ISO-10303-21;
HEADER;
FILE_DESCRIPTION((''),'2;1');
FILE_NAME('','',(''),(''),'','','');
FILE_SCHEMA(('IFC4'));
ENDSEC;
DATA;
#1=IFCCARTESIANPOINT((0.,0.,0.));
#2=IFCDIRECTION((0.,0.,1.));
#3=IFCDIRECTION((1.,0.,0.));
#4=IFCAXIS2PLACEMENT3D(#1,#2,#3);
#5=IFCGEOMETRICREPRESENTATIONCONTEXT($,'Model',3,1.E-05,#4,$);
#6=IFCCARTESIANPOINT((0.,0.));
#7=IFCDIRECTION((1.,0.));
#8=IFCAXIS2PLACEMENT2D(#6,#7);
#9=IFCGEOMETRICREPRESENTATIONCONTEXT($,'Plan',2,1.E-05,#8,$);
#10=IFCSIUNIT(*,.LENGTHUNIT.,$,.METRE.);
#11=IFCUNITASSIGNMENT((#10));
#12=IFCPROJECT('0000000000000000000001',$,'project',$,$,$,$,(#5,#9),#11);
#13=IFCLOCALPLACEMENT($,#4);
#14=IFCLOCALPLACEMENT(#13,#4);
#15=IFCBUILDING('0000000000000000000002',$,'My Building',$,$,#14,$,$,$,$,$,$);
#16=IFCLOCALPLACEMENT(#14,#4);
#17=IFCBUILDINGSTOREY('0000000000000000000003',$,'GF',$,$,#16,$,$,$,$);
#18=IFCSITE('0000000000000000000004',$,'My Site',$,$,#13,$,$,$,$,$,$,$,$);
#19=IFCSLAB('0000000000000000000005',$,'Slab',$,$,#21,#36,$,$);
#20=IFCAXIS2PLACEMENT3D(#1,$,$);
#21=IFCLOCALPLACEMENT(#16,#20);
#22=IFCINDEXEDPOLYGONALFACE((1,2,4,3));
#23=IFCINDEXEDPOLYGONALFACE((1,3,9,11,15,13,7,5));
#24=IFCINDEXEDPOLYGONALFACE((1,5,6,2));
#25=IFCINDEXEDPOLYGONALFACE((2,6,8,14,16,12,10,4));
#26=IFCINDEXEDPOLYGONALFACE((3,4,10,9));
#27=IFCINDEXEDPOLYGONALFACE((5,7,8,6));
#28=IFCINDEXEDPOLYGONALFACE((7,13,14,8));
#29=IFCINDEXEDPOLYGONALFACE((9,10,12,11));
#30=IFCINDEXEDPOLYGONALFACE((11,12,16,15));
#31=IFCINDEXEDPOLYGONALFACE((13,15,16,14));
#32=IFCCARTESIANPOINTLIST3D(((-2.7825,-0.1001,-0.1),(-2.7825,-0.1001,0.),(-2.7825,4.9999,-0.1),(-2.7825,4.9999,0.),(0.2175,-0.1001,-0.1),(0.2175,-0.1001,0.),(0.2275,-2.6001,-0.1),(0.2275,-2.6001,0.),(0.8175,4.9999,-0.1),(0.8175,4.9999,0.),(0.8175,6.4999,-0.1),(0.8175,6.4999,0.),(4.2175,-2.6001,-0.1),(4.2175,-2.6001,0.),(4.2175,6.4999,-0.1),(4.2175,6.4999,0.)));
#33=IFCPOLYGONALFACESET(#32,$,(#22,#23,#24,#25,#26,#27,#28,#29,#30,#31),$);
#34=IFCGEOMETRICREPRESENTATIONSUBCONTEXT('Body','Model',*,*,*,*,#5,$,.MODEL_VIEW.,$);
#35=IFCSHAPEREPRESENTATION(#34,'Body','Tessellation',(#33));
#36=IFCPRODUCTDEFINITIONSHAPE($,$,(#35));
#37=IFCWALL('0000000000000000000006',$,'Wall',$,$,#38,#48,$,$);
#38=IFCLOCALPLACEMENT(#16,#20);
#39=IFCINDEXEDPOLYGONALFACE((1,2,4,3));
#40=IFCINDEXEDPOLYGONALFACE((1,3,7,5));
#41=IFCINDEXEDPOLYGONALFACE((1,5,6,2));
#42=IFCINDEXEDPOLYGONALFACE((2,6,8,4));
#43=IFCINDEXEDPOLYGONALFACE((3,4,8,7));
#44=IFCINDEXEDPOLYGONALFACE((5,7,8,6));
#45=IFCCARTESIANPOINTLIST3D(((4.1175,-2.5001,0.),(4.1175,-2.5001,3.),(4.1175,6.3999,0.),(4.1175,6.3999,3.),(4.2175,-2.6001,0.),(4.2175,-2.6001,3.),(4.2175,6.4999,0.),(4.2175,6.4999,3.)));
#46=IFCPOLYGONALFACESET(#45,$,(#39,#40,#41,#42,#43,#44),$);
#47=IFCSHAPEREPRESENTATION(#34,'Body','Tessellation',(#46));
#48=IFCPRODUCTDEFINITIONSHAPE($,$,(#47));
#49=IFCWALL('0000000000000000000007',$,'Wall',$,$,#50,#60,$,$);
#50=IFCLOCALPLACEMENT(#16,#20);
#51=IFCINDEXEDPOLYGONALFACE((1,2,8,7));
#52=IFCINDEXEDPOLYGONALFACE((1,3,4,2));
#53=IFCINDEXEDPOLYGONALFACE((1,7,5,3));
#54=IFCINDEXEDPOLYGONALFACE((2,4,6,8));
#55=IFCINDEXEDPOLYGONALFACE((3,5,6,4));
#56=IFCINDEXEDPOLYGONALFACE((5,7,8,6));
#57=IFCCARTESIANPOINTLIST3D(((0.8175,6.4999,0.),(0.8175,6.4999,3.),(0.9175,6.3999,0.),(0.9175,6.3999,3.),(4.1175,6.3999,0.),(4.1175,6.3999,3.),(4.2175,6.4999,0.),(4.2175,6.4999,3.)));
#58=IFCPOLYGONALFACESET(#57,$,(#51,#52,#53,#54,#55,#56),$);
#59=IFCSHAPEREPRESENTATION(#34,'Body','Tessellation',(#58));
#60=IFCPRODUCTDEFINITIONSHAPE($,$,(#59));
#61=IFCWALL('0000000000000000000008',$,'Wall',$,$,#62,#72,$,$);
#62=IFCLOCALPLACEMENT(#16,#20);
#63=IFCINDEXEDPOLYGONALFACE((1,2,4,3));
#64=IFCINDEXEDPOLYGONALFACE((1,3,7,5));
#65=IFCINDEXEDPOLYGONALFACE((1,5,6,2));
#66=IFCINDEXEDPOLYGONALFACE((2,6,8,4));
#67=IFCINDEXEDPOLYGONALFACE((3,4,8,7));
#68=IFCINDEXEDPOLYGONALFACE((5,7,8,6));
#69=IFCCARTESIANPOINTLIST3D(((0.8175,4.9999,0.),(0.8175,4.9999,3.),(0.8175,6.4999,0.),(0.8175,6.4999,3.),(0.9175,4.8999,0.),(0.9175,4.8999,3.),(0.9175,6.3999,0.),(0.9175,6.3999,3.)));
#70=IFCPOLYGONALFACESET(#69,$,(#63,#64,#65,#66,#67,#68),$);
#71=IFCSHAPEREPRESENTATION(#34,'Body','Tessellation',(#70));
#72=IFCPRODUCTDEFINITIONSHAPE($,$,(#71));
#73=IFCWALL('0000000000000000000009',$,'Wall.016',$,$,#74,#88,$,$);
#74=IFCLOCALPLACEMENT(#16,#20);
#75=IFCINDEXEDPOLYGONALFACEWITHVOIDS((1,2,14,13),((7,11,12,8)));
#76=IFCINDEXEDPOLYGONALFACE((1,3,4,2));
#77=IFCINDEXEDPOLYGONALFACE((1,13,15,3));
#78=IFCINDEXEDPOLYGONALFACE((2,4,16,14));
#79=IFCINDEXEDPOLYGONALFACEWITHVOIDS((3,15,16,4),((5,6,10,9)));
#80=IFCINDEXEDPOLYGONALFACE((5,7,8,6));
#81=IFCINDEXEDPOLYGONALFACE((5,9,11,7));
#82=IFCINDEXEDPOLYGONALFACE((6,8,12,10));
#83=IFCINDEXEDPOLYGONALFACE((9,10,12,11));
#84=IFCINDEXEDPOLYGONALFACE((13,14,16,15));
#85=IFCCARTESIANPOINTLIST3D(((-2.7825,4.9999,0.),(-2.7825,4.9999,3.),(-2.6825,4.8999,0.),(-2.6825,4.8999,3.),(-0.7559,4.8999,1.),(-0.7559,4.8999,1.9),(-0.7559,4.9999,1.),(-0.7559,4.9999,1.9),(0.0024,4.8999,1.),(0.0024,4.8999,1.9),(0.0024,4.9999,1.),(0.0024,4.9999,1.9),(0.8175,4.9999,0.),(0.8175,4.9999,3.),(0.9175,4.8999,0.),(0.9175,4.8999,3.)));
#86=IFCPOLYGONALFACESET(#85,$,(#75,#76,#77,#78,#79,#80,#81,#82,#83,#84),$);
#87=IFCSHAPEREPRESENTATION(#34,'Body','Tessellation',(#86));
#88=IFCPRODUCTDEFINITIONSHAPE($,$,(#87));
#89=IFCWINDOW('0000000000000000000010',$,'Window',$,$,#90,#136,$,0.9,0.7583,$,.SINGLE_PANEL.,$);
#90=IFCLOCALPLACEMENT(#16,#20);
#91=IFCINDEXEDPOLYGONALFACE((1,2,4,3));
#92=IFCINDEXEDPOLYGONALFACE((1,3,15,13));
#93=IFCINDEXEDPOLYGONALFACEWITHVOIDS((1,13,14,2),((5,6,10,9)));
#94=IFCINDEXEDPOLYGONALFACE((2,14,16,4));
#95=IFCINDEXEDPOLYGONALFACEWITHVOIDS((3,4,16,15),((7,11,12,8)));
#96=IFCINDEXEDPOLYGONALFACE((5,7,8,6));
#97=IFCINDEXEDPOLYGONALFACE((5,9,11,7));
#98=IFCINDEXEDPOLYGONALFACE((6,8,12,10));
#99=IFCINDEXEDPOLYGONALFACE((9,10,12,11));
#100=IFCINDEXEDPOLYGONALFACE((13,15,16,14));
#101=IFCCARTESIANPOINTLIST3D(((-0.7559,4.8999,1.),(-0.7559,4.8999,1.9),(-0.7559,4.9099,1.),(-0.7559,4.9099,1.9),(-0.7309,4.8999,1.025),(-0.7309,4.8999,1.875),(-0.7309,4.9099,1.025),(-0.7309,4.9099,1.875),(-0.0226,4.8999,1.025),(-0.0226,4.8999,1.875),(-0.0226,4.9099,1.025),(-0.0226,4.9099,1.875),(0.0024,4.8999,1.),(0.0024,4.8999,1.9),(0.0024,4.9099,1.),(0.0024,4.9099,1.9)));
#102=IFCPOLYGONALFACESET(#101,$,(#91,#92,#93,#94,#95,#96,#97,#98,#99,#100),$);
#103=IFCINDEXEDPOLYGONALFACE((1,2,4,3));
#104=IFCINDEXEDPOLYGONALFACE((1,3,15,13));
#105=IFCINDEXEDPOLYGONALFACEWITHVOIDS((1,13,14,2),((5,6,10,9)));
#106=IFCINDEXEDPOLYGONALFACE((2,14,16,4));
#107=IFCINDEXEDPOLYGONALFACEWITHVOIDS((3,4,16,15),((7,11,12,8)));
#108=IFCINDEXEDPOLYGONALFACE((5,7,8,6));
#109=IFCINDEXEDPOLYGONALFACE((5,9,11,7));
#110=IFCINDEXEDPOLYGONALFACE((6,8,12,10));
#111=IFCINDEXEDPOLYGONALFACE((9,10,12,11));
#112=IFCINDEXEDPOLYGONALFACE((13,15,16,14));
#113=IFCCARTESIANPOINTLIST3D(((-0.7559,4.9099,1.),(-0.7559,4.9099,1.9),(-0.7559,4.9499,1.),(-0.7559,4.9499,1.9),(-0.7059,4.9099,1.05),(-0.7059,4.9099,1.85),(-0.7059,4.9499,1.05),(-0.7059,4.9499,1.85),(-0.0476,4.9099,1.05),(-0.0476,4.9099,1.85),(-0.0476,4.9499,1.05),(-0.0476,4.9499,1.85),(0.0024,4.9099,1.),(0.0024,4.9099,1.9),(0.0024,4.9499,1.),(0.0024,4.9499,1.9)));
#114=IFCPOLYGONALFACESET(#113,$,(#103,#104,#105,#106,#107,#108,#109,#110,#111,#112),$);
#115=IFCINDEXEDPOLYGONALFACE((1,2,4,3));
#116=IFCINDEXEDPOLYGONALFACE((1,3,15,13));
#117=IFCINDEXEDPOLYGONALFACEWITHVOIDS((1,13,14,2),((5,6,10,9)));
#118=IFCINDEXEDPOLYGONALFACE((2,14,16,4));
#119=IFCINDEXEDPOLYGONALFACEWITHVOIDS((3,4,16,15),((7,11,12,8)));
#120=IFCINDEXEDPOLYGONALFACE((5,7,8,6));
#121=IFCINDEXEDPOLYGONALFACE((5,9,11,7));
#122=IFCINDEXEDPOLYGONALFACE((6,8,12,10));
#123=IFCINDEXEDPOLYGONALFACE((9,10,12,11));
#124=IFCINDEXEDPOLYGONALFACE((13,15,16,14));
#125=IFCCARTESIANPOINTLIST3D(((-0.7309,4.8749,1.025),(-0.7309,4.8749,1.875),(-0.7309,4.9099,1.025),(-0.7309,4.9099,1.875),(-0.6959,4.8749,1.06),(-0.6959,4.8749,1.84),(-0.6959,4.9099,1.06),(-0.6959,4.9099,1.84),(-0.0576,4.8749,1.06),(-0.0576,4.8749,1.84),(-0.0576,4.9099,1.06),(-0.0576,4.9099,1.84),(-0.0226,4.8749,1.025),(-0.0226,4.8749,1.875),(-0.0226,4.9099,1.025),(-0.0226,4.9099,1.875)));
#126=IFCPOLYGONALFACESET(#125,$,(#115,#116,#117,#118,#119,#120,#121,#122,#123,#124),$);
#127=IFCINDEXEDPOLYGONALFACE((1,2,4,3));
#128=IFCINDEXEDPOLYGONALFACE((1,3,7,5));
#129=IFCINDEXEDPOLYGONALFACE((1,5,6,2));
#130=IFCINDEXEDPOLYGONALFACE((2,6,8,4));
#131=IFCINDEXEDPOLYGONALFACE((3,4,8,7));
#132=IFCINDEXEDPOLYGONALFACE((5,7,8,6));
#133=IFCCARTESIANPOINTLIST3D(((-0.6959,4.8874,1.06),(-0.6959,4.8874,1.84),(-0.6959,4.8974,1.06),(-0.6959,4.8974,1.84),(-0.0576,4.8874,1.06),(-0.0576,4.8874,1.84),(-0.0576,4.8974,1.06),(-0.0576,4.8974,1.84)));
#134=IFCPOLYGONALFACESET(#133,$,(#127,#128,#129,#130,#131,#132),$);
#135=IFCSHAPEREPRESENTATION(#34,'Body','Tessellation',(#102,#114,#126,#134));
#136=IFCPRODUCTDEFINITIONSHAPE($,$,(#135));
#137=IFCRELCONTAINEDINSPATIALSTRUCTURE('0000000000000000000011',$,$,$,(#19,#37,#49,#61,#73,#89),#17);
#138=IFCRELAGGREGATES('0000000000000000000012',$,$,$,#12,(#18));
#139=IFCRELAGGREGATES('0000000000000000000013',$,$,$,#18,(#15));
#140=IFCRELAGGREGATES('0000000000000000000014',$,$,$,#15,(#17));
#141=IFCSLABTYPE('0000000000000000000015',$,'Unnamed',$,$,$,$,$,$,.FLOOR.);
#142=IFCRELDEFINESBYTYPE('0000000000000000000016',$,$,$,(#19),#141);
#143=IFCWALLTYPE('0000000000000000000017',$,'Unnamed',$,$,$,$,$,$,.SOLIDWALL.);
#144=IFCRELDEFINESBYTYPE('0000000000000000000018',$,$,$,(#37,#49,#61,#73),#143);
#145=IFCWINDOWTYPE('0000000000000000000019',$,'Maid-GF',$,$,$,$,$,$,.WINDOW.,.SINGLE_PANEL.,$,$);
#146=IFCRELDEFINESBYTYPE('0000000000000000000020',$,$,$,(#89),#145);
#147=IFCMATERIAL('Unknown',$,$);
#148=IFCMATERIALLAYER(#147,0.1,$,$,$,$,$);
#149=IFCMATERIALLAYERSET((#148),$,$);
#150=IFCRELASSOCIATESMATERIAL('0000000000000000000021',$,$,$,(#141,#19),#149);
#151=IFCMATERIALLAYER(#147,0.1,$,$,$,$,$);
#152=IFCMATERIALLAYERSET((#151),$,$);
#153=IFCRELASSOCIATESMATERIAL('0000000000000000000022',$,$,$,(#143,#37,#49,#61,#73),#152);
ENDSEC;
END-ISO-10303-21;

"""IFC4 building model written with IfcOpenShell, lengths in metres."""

from ifc_helpers import new_model, entity, si_unit, frame, origin_with_axes, origin_2d_with_axis, place, context, subcontext, project, spatial, line, indexed_curve, outline, extrude, shape, source, transform, mapped, material, layer, layer_set, layer_usage, type_object, type_shapes, element, fill, save


model = new_model("IFC4")

# Units and contexts
model_context = context("Model", 3, precision=1e-05, world=origin_with_axes())
plan_context = context("Plan", 2, precision=1e-05, world=origin_2d_with_axis())
body_context_1 = subcontext(model_context, "Body", "Model", "MODEL_VIEW")
body_context_2 = subcontext(plan_context, "Body", "Plan", "PLAN_VIEW")
ifc_project = project(units=[si_unit("LENGTHUNIT", "METRE")], contexts=[model_context, plan_context])

# Site, building, storey
site_placement = place(None, origin_with_axes())
site = spatial("IfcSite", under=ifc_project, at=site_placement, Name="My Site")
building_placement = place(site_placement, origin_with_axes())
building = spatial("IfcBuilding", under=site, at=building_placement, Name="My Building")
storey_placement = place(building_placement, origin_with_axes())
storey = spatial("IfcBuildingStorey", under=building, at=storey_placement, Name="GF")

# Slab
ifc_material = material(Name="Unknown")
ifc_layer_1 = layer(ifc_material, 0.1)
ifc_layer_set_1 = layer_set([ifc_layer_1])
ifc_layer_usage_1 = layer_usage(ifc_layer_set_1, "AXIS3", "POSITIVE", -0.1)
slab_type = type_object("IfcSlabType", Name="Unnamed", PredefinedType="FLOOR", material=ifc_layer_set_1)
slab_placement = place(storey_placement, frame((4.2175, -2.6001, 0.0), z_axis=(0.0, 0.0, 1.0), x_axis=(1.0, 0.0, 0.0)))
element("IfcSlab", 1, at=slab_placement, inside=storey, type_object=slab_type, material=ifc_layer_usage_1, Name="Slab", context=body_context_1, shape_type="SweptSolid", body=[
    extrude(outline(indexed_curve([(0.0, 0.0), (0.0, 9.1), (-3.4, 9.1), (-3.4, 7.6), (-7.0, 7.6), (-7.0, 2.5), (-4.0, 2.5), (-3.99, 0.0), (0.0, 0.0)])), frame((0.0, 0.0, -0.1), z_axis=(0.0, 0.0, 1.0), x_axis=(1.0, 0.0, 0.0)), (0.0, 0.0, 1.0), 0.1),
])

# Shared definitions
ifc_layer_2 = layer(ifc_material, 0.1)
ifc_layer_set_2 = layer_set([ifc_layer_2])
wall_type = type_object("IfcWallType", Name="Unnamed", PredefinedType="SOLIDWALL", material=ifc_layer_set_2)

# Walls
ifc_layer_usage_2 = layer_usage(ifc_layer_set_2, "AXIS2", "POSITIVE", 0.0)
wall_1_placement = place(storey_placement, frame((4.2175, -2.6001, 0.0), z_axis=(0.0, 0.0, 1.0), x_axis=(0.0, 1.0, 0.0)))
element("IfcWall", 2, at=wall_1_placement, inside=storey, type_object=wall_type, material=ifc_layer_usage_2, Name="Wall", context=body_context_1, shape_type="SweptSolid", body=[
    extrude(outline(indexed_curve([(0.0, 0.0), (0.1, 0.1), (9.0, 0.1), (9.1, 0.0)], segments=[line(1, 2, 3, 4, 1)])), origin_with_axes(), (0.0, 0.0, 1.0), 3.0),
])
ifc_layer_usage_3 = layer_usage(ifc_layer_set_2, "AXIS2", "POSITIVE", 0.0)
wall_2_placement = place(storey_placement, frame((4.2175, 6.4999, 0.0), z_axis=(0.0, 0.0, 1.0), x_axis=(-1.0, 0.0, 0.0)))
element("IfcWall", 3, at=wall_2_placement, inside=storey, type_object=wall_type, material=ifc_layer_usage_3, Name="Wall", context=body_context_1, shape_type="SweptSolid", body=[
    extrude(outline(indexed_curve([(0.0, 0.0), (0.1, 0.1), (3.3, 0.1), (3.4, 0.0)], segments=[line(1, 2, 3, 4, 1)])), origin_with_axes(), (0.0, 0.0, 1.0), 3.0),
])
ifc_layer_usage_4 = layer_usage(ifc_layer_set_2, "AXIS2", "POSITIVE", 0.0)
wall_3_placement = place(storey_placement, frame((0.8175, 6.4999, 0.0), z_axis=(0.0, 0.0, 1.0), x_axis=(0.0, -1.0, 0.0)))
element("IfcWall", 4, at=wall_3_placement, inside=storey, type_object=wall_type, material=ifc_layer_usage_4, Name="Wall", context=body_context_1, shape_type="SweptSolid", body=[
    extrude(outline(indexed_curve([(0.0, 0.0), (0.1, 0.1), (1.6, 0.1), (1.5, 0.0)], segments=[line(1, 2, 3, 4, 1)])), origin_with_axes(), (0.0, 0.0, 1.0), 3.0),
])

# Wall, opening, window
ifc_layer_usage_5 = layer_usage(ifc_layer_set_2, "AXIS2", "POSITIVE", 0.0)
wall_4_placement = place(storey_placement, frame((0.8175, 4.9999, 0.0), z_axis=(0.0, 0.0, 1.0), x_axis=(-1.0, 0.0, 0.0)))
wall_4 = element("IfcWall", 5, at=wall_4_placement, inside=storey, type_object=wall_type, material=ifc_layer_usage_5, Name="Wall.016", context=body_context_1, shape_type="SweptSolid", body=[
    extrude(outline(indexed_curve([(0.0, 0.0), (-0.1, 0.1), (3.5, 0.1), (3.6, 0.0)], segments=[line(1, 2, 3, 4, 1)])), origin_with_axes(), (0.0, 0.0, 1.0), 3.0),
])
shared_shape_1 = source(origin_with_axes(), body_context_1, "Body", "SweptSolid", [
    extrude(outline(indexed_curve([(0.0, 0.0), (0.7583, 0.0), (0.7583, 0.9), (0.0, 0.9)], segments=[line(1, 2, 3, 4, 1)])), frame((0.0, -0.6, 0.0), z_axis=(0.0, -1.0, 0.0), x_axis=(1.0, 0.0, 0.0)), (0.0, 0.0, -1.0), 1.2),
])
opening_1_placement = place(wall_4_placement, frame((0.8151, 0.0, 1.0), z_axis=(0.0, 0.0, 1.0), x_axis=(1.0, 0.0, 0.0)))
opening_1 = element("IfcOpeningElement", 6, at=opening_1_placement, cuts=wall_4, PredefinedType="OPENING", context=body_context_1, shape_type="MappedRepresentation", body=[
    mapped(shared_shape_1, transform((0.0, 0.0, 0.0), x_axis=(1.0, 0.0, 0.0), y_axis=(0.0, 1.0, 0.0), z_axis=(0.0, 0.0, 1.0), scale=1.0)),
])
window_type_1 = type_object("IfcWindowType", Name="Maid-GF", PartitioningType="SINGLE_PANEL", PredefinedType="WINDOW")
shared_shape_2 = source(origin_with_axes(), body_context_1, "Body", "SweptSolid", [
    extrude(outline(indexed_curve([(0.0, 0.0), (0.7583, 0.0), (0.7583, 0.9), (0.0, 0.9)], segments=[line(1, 2, 3, 4, 1)]), holes=[indexed_curve([(0.025, 0.025), (0.7333, 0.025), (0.7333, 0.875), (0.025, 0.875)], segments=[line(1, 2, 3, 4, 1)])]), frame((0.0, 0.09, 0.0), z_axis=(0.0, -1.0, 0.0), x_axis=(1.0, 0.0, 0.0)), (0.0, 0.0, -1.0), 0.01),
    extrude(outline(indexed_curve([(0.0, 0.0), (0.7583, 0.0), (0.7583, 0.9), (0.0, 0.9)], segments=[line(1, 2, 3, 4, 1)]), holes=[indexed_curve([(0.05, 0.05), (0.7083, 0.05), (0.7083, 0.85), (0.05, 0.85)], segments=[line(1, 2, 3, 4, 1)])]), frame((0.0, 0.05, 0.0), z_axis=(0.0, -1.0, 0.0), x_axis=(1.0, 0.0, 0.0)), (0.0, 0.0, -1.0), 0.04),
    extrude(outline(indexed_curve([(0.0, 0.0), (0.7083, 0.0), (0.7083, 0.85), (0.0, 0.85)], segments=[line(1, 2, 3, 4, 1)]), holes=[indexed_curve([(0.035, 0.035), (0.6733, 0.035), (0.6733, 0.815), (0.035, 0.815)], segments=[line(1, 2, 3, 4, 1)])]), frame((0.025, 0.09, 0.025), z_axis=(0.0, -1.0, 0.0), x_axis=(1.0, 0.0, 0.0)), (0.0, 0.0, -1.0), 0.035),
    extrude(outline(indexed_curve([(0.035, 0.035), (0.6733, 0.035), (0.6733, 0.815), (0.035, 0.815)], segments=[line(1, 2, 3, 4, 1)])), frame((0.025, 0.1025, 0.025), z_axis=(0.0, -1.0, 0.0), x_axis=(1.0, 0.0, 0.0)), (0.0, 0.0, -1.0), 0.01),
])
shared_shape_3 = source(origin_with_axes(), body_context_2, "Body", "Curve2D", [
    entity("IfcIndexedPolyCurve", entity("IfcCartesianPointList2D", [[0.05, 0.05], [0.7083, 0.05]])),
    entity("IfcIndexedPolyCurve", entity("IfcCartesianPointList2D", [[0.0, 0.1], [0.025, 0.1], [0.025, 0.09], [0.05, 0.09], [0.05, 0.05], [0.0, 0.05]]), [entity("IfcLineIndex", [1, 2, 3, 4, 5, 6, 1])]),
    entity("IfcIndexedPolyCurve", entity("IfcCartesianPointList2D", [[0.7583, 0.1], [0.7333, 0.1], [0.7333, 0.09], [0.7083, 0.09], [0.7083, 0.05], [0.7583, 0.05]]), [entity("IfcLineIndex", [1, 2, 3, 4, 5, 6, 1])]),
    entity("IfcIndexedPolyCurve", entity("IfcCartesianPointList2D", [[0.025, 0.09], [0.06, 0.09], [0.06, 0.125], [0.025, 0.125]]), [entity("IfcLineIndex", [1, 2, 3, 4, 1])]),
    entity("IfcIndexedPolyCurve", entity("IfcCartesianPointList2D", [[0.7333, 0.09], [0.6983, 0.09], [0.6983, 0.125], [0.7333, 0.125]]), [entity("IfcLineIndex", [1, 2, 3, 4, 1])]),
    entity("IfcIndexedPolyCurve", entity("IfcCartesianPointList2D", [[0.06, 0.09], [0.6983, 0.09]])),
    entity("IfcIndexedPolyCurve", entity("IfcCartesianPointList2D", [[0.06, 0.125], [0.6983, 0.125]])),
    entity("IfcIndexedPolyCurve", entity("IfcCartesianPointList2D", [[0.06, 0.1075], [0.6983, 0.1075]])),
])
type_shapes(window_type_1, [shared_shape_2, shared_shape_3])
window_1_placement = place(opening_1_placement, frame((0.0, 0.0, 0.0), z_axis=(0.0, 0.0, 1.0), x_axis=(1.0, 0.0, 0.0)))
window_1 = element("IfcWindow", 7, at=window_1_placement, inside=storey, type_object=window_type_1, Name="Window", OverallHeight=0.9, OverallWidth=0.7583, PartitioningType="SINGLE_PANEL", shapes=[
    shape(body_context_1, "Body", "MappedRepresentation", [mapped(shared_shape_2, transform((0.0, 0.0, 0.0), x_axis=(1.0, 0.0, 0.0), y_axis=(0.0, 1.0, 0.0), z_axis=(0.0, 0.0, 1.0), scale=1.0))]),
    shape(body_context_2, "Body", "MappedRepresentation", [mapped(shared_shape_3, transform((0.0, 0.0, 0.0), x_axis=(1.0, 0.0, 0.0), y_axis=(0.0, 1.0, 0.0), z_axis=(0.0, 0.0, 1.0), scale=1.0))]),
])
fill(opening_1, window_1)

save(model, "model.ifc")
